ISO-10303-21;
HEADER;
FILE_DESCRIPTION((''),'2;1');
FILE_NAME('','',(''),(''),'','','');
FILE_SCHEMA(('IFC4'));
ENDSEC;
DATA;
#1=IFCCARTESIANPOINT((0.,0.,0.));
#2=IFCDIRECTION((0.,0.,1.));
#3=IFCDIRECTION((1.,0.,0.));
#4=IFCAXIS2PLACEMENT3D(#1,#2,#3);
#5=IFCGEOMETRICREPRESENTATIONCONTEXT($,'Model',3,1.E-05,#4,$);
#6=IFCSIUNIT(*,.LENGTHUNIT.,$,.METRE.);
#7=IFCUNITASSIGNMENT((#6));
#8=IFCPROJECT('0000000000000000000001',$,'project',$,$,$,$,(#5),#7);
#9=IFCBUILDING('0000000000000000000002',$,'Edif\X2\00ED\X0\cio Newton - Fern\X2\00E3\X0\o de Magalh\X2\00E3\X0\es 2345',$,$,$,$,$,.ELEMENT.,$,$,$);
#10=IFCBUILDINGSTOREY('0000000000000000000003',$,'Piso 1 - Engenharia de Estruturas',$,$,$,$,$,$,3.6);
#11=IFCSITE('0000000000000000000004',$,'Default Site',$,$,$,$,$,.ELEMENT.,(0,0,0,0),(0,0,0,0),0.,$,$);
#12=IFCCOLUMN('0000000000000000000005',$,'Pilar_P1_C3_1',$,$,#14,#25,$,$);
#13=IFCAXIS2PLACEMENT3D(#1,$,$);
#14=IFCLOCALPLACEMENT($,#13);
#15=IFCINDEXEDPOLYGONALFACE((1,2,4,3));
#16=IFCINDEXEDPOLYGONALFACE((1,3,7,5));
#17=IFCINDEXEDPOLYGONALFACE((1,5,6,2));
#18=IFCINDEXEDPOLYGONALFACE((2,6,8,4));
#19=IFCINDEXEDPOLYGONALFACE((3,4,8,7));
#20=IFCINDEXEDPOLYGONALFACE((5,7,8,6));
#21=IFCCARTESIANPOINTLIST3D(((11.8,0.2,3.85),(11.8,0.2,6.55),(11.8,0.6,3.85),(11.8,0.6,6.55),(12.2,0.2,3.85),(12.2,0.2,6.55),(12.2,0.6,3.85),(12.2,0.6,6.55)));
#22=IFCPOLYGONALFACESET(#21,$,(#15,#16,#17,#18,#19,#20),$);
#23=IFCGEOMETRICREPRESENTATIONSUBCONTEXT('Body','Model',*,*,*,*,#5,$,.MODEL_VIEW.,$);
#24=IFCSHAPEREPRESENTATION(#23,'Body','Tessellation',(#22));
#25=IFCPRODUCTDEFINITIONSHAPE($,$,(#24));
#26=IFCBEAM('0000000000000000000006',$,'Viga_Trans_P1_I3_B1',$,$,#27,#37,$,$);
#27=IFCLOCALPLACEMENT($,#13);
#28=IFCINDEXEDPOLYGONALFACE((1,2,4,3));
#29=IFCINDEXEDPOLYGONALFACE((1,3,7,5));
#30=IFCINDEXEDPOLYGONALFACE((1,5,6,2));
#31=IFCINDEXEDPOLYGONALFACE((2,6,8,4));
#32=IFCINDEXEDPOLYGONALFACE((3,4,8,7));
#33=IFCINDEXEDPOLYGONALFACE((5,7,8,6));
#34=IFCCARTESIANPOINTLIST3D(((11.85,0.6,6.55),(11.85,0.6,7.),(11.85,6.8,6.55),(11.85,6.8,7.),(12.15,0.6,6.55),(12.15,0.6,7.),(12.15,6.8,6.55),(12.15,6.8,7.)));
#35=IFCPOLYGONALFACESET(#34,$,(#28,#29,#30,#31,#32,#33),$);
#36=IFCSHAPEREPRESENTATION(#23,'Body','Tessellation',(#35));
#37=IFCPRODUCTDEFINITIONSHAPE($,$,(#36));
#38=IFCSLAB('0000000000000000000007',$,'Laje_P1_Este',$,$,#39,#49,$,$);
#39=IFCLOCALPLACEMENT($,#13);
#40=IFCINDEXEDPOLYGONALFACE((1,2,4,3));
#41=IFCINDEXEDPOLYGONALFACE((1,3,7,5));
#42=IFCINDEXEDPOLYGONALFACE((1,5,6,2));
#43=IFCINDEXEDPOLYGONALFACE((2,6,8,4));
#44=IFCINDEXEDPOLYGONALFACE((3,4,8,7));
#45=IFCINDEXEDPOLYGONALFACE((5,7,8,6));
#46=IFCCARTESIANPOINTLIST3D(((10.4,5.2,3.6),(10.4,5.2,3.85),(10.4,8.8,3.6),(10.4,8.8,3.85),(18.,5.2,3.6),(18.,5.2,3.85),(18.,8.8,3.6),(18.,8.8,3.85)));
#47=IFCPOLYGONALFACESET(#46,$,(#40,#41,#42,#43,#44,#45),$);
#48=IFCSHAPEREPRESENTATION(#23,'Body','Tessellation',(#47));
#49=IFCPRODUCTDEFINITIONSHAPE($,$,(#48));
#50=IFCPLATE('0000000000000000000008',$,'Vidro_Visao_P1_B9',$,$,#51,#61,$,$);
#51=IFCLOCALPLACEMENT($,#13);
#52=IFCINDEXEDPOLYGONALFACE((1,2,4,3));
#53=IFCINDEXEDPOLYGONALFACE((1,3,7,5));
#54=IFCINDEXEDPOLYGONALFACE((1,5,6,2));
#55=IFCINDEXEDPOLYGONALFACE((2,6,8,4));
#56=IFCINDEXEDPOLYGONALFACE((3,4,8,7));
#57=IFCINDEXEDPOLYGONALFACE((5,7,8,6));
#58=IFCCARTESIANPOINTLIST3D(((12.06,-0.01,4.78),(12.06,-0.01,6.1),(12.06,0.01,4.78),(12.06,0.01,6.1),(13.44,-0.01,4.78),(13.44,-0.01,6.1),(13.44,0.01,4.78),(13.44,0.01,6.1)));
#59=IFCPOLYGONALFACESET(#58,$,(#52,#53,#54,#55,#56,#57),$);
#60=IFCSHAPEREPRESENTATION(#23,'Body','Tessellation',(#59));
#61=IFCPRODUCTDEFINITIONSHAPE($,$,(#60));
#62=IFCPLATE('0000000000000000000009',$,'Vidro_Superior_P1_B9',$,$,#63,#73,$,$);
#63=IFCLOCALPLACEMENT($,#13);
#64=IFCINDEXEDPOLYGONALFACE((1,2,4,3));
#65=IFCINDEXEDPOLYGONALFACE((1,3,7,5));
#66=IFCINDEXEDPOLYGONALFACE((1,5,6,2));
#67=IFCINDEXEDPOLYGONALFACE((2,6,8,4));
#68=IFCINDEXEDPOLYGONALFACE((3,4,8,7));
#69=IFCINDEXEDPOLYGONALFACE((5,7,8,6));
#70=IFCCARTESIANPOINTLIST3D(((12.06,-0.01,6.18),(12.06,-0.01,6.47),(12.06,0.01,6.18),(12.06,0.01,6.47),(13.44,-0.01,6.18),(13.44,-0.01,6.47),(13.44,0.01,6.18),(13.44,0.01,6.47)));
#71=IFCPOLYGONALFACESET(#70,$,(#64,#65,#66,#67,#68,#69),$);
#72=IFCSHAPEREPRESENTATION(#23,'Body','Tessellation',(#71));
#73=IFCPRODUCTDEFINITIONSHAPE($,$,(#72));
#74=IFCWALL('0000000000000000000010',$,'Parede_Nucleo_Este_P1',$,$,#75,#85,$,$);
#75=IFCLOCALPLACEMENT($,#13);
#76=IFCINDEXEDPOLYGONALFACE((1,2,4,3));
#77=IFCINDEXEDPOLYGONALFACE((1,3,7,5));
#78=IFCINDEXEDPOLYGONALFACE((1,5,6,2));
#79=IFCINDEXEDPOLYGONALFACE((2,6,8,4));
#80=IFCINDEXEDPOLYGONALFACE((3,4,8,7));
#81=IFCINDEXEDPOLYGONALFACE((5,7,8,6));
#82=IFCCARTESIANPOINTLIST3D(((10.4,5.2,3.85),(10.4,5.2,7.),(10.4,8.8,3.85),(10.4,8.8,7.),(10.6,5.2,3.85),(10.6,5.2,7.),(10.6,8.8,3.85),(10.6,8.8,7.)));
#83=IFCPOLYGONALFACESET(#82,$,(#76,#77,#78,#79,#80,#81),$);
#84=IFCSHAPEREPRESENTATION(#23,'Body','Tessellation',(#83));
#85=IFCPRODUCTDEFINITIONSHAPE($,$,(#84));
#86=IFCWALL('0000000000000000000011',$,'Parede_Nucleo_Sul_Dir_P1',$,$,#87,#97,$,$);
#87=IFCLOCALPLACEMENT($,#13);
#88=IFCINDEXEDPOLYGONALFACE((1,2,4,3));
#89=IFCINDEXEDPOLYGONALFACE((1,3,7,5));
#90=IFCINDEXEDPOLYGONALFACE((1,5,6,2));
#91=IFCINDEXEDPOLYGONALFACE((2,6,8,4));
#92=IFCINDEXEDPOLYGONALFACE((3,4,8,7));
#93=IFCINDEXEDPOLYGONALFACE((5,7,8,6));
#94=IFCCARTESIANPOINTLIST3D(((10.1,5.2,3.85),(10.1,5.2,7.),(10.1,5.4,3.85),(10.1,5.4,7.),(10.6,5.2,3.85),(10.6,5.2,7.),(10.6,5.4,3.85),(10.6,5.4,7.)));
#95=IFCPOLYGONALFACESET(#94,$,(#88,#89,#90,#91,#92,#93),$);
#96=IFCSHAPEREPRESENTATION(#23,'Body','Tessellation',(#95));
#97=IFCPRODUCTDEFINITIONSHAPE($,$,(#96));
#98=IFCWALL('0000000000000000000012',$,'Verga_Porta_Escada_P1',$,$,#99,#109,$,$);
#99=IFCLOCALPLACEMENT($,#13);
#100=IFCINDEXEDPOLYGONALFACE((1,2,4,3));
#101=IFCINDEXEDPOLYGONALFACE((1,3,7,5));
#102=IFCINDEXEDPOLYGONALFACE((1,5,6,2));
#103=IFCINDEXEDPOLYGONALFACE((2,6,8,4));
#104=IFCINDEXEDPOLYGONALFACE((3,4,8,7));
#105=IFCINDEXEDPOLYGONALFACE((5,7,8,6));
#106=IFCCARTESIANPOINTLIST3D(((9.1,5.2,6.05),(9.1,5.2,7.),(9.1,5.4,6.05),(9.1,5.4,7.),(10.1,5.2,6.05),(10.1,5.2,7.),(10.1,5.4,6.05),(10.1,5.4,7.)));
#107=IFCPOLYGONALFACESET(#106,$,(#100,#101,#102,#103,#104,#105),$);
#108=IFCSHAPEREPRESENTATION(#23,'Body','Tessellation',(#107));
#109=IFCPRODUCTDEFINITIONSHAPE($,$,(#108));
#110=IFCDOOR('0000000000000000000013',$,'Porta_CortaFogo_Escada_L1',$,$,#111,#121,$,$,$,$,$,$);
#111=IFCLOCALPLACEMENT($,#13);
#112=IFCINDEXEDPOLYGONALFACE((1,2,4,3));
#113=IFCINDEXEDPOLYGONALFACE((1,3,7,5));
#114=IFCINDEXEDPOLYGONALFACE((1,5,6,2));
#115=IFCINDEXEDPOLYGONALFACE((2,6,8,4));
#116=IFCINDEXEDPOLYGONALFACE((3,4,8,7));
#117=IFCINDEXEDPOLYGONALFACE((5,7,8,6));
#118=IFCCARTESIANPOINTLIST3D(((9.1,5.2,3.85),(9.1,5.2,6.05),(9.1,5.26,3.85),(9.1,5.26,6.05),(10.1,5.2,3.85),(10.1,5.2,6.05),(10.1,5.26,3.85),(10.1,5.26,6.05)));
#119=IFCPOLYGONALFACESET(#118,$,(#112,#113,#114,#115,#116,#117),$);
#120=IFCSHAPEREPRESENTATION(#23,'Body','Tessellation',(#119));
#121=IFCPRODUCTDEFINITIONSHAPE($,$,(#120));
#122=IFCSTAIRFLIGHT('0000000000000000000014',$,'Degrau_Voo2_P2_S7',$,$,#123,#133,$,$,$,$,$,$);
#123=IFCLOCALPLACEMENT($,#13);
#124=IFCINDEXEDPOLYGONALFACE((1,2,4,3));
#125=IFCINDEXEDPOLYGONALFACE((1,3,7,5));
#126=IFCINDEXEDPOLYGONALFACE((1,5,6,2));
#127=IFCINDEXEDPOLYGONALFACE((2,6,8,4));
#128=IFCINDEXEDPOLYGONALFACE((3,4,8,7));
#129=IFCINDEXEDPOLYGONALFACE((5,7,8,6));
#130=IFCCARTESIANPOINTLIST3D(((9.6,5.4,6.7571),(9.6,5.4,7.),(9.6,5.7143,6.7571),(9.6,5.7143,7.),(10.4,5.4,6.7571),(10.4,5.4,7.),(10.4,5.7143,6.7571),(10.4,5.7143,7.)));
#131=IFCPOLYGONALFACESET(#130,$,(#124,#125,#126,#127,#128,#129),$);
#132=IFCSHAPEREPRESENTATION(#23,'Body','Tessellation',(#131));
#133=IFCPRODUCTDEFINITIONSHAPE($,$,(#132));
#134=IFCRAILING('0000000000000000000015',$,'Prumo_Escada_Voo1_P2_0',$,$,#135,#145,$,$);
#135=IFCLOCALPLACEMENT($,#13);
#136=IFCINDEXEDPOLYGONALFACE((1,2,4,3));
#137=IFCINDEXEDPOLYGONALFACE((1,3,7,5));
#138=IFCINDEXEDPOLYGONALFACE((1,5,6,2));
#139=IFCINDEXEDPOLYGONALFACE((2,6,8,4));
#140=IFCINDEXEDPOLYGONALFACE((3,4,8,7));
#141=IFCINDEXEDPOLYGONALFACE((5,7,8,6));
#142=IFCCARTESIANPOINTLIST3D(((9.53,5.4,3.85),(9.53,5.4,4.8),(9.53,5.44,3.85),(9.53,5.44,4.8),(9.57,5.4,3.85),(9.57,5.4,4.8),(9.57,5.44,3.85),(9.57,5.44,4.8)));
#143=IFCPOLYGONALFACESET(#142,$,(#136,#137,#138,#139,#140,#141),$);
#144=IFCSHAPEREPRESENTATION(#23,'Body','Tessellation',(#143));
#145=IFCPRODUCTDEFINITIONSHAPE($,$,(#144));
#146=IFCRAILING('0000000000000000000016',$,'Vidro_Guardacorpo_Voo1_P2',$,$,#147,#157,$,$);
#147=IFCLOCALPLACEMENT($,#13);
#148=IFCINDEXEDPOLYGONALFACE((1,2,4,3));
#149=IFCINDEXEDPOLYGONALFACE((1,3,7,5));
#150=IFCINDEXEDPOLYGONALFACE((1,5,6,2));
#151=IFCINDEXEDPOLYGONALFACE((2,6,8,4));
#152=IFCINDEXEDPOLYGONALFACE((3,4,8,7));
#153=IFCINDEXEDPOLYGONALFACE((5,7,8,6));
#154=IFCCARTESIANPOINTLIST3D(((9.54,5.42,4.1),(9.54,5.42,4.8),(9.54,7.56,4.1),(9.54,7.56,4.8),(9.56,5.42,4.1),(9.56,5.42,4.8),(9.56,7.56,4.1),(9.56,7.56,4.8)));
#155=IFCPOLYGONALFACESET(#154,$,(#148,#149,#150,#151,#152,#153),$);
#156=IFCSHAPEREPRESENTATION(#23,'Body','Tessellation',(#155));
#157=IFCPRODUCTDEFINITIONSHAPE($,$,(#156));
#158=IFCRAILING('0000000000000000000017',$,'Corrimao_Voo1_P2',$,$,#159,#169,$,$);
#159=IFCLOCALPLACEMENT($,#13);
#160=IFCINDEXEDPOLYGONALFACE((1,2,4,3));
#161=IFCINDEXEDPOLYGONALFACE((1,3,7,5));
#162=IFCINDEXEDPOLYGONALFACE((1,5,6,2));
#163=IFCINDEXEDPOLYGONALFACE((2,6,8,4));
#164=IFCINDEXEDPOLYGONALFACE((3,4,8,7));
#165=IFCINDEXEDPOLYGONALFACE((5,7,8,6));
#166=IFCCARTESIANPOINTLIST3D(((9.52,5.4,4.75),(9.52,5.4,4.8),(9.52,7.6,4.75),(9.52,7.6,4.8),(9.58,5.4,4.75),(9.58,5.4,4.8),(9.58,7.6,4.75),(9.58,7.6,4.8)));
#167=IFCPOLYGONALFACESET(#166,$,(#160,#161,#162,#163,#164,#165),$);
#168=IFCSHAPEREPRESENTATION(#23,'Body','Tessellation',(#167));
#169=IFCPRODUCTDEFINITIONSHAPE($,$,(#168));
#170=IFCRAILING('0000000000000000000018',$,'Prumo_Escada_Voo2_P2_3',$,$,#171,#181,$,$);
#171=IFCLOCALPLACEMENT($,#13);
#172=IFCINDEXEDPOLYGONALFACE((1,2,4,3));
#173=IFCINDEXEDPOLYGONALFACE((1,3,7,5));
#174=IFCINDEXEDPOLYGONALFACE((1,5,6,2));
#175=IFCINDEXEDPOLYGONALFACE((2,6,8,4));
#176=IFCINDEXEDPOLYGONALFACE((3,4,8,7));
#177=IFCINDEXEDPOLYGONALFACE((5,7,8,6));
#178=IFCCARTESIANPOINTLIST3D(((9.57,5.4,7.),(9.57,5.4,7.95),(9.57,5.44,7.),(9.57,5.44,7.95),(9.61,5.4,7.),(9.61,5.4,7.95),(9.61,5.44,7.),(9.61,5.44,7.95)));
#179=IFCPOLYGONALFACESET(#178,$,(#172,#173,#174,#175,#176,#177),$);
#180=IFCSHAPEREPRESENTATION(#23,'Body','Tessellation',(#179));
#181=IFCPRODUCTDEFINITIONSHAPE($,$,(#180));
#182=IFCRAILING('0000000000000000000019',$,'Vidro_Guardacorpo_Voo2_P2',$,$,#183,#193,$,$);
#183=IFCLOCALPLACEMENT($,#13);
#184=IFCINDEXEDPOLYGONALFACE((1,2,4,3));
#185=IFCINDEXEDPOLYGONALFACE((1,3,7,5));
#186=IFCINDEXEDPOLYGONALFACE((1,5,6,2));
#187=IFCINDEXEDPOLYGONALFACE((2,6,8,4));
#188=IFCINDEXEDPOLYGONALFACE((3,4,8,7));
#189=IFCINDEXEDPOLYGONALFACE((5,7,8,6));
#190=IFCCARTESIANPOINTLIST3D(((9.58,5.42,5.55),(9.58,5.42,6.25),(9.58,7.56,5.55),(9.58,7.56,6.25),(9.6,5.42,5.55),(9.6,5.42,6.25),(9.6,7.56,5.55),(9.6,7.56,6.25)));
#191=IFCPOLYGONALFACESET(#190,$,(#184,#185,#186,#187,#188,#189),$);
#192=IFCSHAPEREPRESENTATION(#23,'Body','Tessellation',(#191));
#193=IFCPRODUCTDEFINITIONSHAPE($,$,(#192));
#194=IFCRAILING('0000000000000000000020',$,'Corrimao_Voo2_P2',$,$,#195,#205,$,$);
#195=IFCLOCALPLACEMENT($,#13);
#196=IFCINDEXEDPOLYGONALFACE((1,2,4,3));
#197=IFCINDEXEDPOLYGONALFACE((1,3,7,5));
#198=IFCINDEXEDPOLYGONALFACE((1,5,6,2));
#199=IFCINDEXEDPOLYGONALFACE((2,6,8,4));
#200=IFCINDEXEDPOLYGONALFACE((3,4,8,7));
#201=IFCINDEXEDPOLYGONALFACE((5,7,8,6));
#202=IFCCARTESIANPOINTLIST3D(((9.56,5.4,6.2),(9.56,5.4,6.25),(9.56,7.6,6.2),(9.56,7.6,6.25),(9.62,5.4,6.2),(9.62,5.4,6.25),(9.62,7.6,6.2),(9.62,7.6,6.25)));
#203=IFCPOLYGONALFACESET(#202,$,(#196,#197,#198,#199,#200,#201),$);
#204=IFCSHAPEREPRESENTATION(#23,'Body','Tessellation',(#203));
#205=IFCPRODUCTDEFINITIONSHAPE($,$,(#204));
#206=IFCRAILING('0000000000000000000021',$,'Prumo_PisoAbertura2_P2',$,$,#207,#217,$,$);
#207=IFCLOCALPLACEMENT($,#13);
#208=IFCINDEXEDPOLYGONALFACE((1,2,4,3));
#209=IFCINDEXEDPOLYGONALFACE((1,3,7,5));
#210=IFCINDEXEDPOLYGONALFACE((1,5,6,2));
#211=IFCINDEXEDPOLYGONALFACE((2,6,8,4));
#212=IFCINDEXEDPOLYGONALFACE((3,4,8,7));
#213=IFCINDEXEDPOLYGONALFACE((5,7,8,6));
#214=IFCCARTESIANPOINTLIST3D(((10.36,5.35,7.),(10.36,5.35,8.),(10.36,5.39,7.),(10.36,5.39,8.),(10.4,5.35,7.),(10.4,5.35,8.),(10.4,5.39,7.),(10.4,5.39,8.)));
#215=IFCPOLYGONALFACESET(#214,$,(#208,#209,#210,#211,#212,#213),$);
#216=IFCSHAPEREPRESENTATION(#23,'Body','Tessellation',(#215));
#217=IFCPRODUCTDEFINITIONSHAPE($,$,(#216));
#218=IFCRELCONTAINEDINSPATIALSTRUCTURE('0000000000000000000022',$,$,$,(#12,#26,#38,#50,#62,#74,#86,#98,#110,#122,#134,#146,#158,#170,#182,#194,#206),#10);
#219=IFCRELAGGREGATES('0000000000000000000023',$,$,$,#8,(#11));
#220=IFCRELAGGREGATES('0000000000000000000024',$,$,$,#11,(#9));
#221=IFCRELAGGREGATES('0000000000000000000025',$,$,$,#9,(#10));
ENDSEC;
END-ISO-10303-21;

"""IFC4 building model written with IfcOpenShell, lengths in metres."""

from ifc_helpers import new_model, si_unit, frame, frame_2d, origin_with_axes, place, context, subcontext, project, spatial, rectangle, extrude, element, save


model = new_model("IFC4")

# Units and contexts
model_context = context("Model", 3, precision=1e-05, world=origin_with_axes())
body_context = subcontext(model_context, "Body", "Model", "MODEL_VIEW")
ifc_project = project(units=[si_unit("LENGTHUNIT", "METRE")], contexts=[model_context])

# Site, building, storey
site = spatial("IfcSite", under=ifc_project, Name="Default Site", CompositionType="ELEMENT", RefLatitude=(0, 0, 0, 0), RefLongitude=(0, 0, 0, 0), RefElevation=0.0)
building = spatial("IfcBuilding", under=site, Name="Edifício Newton - Fernão de Magalhães 2345", CompositionType="ELEMENT")
storey = spatial("IfcBuildingStorey", under=building, Name="Piso 1 - Engenharia de Estruturas", Elevation=3.6)

# Column
column_placement = place(None, frame((11.8, 0.2, 3.85), z_axis=(0.0, 0.0, 1.0), x_axis=(1.0, 0.0, 0.0)))
element("IfcColumn", 1, at=column_placement, inside=storey, Name="Pilar_P1_C3_1", context=body_context, shape_type="SweptSolid", body=[
    extrude(rectangle(XDim=0.4, YDim=0.4, at=frame_2d((0.2, 0.2))), origin_with_axes(), (0.0, 0.0, 1.0), 2.7),
])

# Beam
beam_placement = place(None, frame((11.85, 0.6, 6.55), z_axis=(0.0, 0.0, 1.0), x_axis=(1.0, 0.0, 0.0)))
element("IfcBeam", 2, at=beam_placement, inside=storey, Name="Viga_Trans_P1_I3_B1", context=body_context, shape_type="SweptSolid", body=[
    extrude(rectangle(XDim=0.3, YDim=6.2, at=frame_2d((0.15, 3.1))), origin_with_axes(), (0.0, 0.0, 1.0), 0.45),
])

# Slab
slab_placement = place(None, frame((10.4, 5.2, 3.6), z_axis=(0.0, 0.0, 1.0), x_axis=(1.0, 0.0, 0.0)))
element("IfcSlab", 3, at=slab_placement, inside=storey, Name="Laje_P1_Este", context=body_context, shape_type="SweptSolid", body=[
    extrude(rectangle(XDim=7.6, YDim=3.6, at=frame_2d((3.8, 1.8))), origin_with_axes(), (0.0, 0.0, 1.0), 0.25),
])

# Plates
plate_1_placement = place(None, frame((12.06, -0.01, 4.78), z_axis=(0.0, 0.0, 1.0), x_axis=(1.0, 0.0, 0.0)))
element("IfcPlate", 4, at=plate_1_placement, inside=storey, Name="Vidro_Visao_P1_B9", context=body_context, shape_type="SweptSolid", body=[
    extrude(rectangle(XDim=1.38, YDim=0.02, at=frame_2d((0.69, 0.01))), origin_with_axes(), (0.0, 0.0, 1.0), 1.32),
])
plate_2_placement = place(None, frame((12.06, -0.01, 6.18), z_axis=(0.0, 0.0, 1.0), x_axis=(1.0, 0.0, 0.0)))
element("IfcPlate", 5, at=plate_2_placement, inside=storey, Name="Vidro_Superior_P1_B9", context=body_context, shape_type="SweptSolid", body=[
    extrude(rectangle(XDim=1.38, YDim=0.02, at=frame_2d((0.69, 0.01))), origin_with_axes(), (0.0, 0.0, 1.0), 0.29),
])

# Walls
wall_1_placement = place(None, frame((10.4, 5.2, 3.85), z_axis=(0.0, 0.0, 1.0), x_axis=(1.0, 0.0, 0.0)))
element("IfcWall", 6, at=wall_1_placement, inside=storey, Name="Parede_Nucleo_Este_P1", context=body_context, shape_type="SweptSolid", body=[
    extrude(rectangle(XDim=0.2, YDim=3.6, at=frame_2d((0.1, 1.8))), origin_with_axes(), (0.0, 0.0, 1.0), 3.15),
])
wall_2_placement = place(None, frame((10.1, 5.2, 3.85), z_axis=(0.0, 0.0, 1.0), x_axis=(1.0, 0.0, 0.0)))
element("IfcWall", 7, at=wall_2_placement, inside=storey, Name="Parede_Nucleo_Sul_Dir_P1", context=body_context, shape_type="SweptSolid", body=[
    extrude(rectangle(XDim=0.5, YDim=0.2, at=frame_2d((0.25, 0.1))), origin_with_axes(), (0.0, 0.0, 1.0), 3.15),
])
wall_3_placement = place(None, frame((9.1, 5.2, 6.05), z_axis=(0.0, 0.0, 1.0), x_axis=(1.0, 0.0, 0.0)))
element("IfcWall", 8, at=wall_3_placement, inside=storey, Name="Verga_Porta_Escada_P1", context=body_context, shape_type="SweptSolid", body=[
    extrude(rectangle(XDim=1.0, YDim=0.2, at=frame_2d((0.5, 0.1))), origin_with_axes(), (0.0, 0.0, 1.0), 0.95),
])

# Door
door_placement = place(None, frame((9.1, 5.2, 3.85), z_axis=(0.0, 0.0, 1.0), x_axis=(1.0, 0.0, 0.0)))
element("IfcDoor", 9, at=door_placement, inside=storey, Name="Porta_CortaFogo_Escada_L1", context=body_context, shape_type="SweptSolid", body=[
    extrude(rectangle(XDim=1.0, YDim=0.06, at=frame_2d((0.5, 0.03))), origin_with_axes(), (0.0, 0.0, 1.0), 2.2),
])

# Stair flight
stair_flight_placement = place(None, frame((9.6, 5.4, 6.7571), z_axis=(0.0, 0.0, 1.0), x_axis=(1.0, 0.0, 0.0)))
element("IfcStairFlight", 10, at=stair_flight_placement, inside=storey, Name="Degrau_Voo2_P2_S7", context=body_context, shape_type="SweptSolid", body=[
    extrude(rectangle(XDim=0.8, YDim=0.3143, at=frame_2d((0.4, 0.1571))), origin_with_axes(), (0.0, 0.0, 1.0), 0.2429),
])

# Railings
railing_1_placement = place(None, frame((9.53, 5.4, 3.85), z_axis=(0.0, 0.0, 1.0), x_axis=(1.0, 0.0, 0.0)))
element("IfcRailing", 11, at=railing_1_placement, inside=storey, Name="Prumo_Escada_Voo1_P2_0", context=body_context, shape_type="SweptSolid", body=[
    extrude(rectangle(XDim=0.04, YDim=0.04, at=frame_2d((0.02, 0.02))), origin_with_axes(), (0.0, 0.0, 1.0), 0.95),
])
railing_2_placement = place(None, frame((9.54, 5.42, 4.1), z_axis=(0.0, 0.0, 1.0), x_axis=(1.0, 0.0, 0.0)))
element("IfcRailing", 12, at=railing_2_placement, inside=storey, Name="Vidro_Guardacorpo_Voo1_P2", context=body_context, shape_type="SweptSolid", body=[
    extrude(rectangle(XDim=0.02, YDim=2.14, at=frame_2d((0.01, 1.07))), origin_with_axes(), (0.0, 0.0, 1.0), 0.7),
])
railing_3_placement = place(None, frame((9.52, 5.4, 4.75), z_axis=(0.0, 0.0, 1.0), x_axis=(1.0, 0.0, 0.0)))
element("IfcRailing", 13, at=railing_3_placement, inside=storey, Name="Corrimao_Voo1_P2", context=body_context, shape_type="SweptSolid", body=[
    extrude(rectangle(XDim=0.06, YDim=2.2, at=frame_2d((0.03, 1.1))), origin_with_axes(), (0.0, 0.0, 1.0), 0.05),
])
railing_4_placement = place(None, frame((9.57, 5.4, 7.0), z_axis=(0.0, 0.0, 1.0), x_axis=(1.0, 0.0, 0.0)))
element("IfcRailing", 14, at=railing_4_placement, inside=storey, Name="Prumo_Escada_Voo2_P2_3", context=body_context, shape_type="SweptSolid", body=[
    extrude(rectangle(XDim=0.04, YDim=0.04, at=frame_2d((0.02, 0.02))), origin_with_axes(), (0.0, 0.0, 1.0), 0.95),
])
railing_5_placement = place(None, frame((9.58, 5.42, 5.55), z_axis=(0.0, 0.0, 1.0), x_axis=(1.0, 0.0, 0.0)))
element("IfcRailing", 15, at=railing_5_placement, inside=storey, Name="Vidro_Guardacorpo_Voo2_P2", context=body_context, shape_type="SweptSolid", body=[
    extrude(rectangle(XDim=0.02, YDim=2.14, at=frame_2d((0.01, 1.07))), origin_with_axes(), (0.0, 0.0, 1.0), 0.7),
])
railing_6_placement = place(None, frame((9.56, 5.4, 6.2), z_axis=(0.0, 0.0, 1.0), x_axis=(1.0, 0.0, 0.0)))
element("IfcRailing", 16, at=railing_6_placement, inside=storey, Name="Corrimao_Voo2_P2", context=body_context, shape_type="SweptSolid", body=[
    extrude(rectangle(XDim=0.06, YDim=2.2, at=frame_2d((0.03, 1.1))), origin_with_axes(), (0.0, 0.0, 1.0), 0.05),
])
railing_7_placement = place(None, frame((10.36, 5.35, 7.0), z_axis=(0.0, 0.0, 1.0), x_axis=(1.0, 0.0, 0.0)))
element("IfcRailing", 17, at=railing_7_placement, inside=storey, Name="Prumo_PisoAbertura2_P2", context=body_context, shape_type="SweptSolid", body=[
    extrude(rectangle(XDim=0.04, YDim=0.04, at=frame_2d((0.02, 0.02))), origin_with_axes(), (0.0, 0.0, 1.0), 1.0),
])

save(model, "model.ifc")
